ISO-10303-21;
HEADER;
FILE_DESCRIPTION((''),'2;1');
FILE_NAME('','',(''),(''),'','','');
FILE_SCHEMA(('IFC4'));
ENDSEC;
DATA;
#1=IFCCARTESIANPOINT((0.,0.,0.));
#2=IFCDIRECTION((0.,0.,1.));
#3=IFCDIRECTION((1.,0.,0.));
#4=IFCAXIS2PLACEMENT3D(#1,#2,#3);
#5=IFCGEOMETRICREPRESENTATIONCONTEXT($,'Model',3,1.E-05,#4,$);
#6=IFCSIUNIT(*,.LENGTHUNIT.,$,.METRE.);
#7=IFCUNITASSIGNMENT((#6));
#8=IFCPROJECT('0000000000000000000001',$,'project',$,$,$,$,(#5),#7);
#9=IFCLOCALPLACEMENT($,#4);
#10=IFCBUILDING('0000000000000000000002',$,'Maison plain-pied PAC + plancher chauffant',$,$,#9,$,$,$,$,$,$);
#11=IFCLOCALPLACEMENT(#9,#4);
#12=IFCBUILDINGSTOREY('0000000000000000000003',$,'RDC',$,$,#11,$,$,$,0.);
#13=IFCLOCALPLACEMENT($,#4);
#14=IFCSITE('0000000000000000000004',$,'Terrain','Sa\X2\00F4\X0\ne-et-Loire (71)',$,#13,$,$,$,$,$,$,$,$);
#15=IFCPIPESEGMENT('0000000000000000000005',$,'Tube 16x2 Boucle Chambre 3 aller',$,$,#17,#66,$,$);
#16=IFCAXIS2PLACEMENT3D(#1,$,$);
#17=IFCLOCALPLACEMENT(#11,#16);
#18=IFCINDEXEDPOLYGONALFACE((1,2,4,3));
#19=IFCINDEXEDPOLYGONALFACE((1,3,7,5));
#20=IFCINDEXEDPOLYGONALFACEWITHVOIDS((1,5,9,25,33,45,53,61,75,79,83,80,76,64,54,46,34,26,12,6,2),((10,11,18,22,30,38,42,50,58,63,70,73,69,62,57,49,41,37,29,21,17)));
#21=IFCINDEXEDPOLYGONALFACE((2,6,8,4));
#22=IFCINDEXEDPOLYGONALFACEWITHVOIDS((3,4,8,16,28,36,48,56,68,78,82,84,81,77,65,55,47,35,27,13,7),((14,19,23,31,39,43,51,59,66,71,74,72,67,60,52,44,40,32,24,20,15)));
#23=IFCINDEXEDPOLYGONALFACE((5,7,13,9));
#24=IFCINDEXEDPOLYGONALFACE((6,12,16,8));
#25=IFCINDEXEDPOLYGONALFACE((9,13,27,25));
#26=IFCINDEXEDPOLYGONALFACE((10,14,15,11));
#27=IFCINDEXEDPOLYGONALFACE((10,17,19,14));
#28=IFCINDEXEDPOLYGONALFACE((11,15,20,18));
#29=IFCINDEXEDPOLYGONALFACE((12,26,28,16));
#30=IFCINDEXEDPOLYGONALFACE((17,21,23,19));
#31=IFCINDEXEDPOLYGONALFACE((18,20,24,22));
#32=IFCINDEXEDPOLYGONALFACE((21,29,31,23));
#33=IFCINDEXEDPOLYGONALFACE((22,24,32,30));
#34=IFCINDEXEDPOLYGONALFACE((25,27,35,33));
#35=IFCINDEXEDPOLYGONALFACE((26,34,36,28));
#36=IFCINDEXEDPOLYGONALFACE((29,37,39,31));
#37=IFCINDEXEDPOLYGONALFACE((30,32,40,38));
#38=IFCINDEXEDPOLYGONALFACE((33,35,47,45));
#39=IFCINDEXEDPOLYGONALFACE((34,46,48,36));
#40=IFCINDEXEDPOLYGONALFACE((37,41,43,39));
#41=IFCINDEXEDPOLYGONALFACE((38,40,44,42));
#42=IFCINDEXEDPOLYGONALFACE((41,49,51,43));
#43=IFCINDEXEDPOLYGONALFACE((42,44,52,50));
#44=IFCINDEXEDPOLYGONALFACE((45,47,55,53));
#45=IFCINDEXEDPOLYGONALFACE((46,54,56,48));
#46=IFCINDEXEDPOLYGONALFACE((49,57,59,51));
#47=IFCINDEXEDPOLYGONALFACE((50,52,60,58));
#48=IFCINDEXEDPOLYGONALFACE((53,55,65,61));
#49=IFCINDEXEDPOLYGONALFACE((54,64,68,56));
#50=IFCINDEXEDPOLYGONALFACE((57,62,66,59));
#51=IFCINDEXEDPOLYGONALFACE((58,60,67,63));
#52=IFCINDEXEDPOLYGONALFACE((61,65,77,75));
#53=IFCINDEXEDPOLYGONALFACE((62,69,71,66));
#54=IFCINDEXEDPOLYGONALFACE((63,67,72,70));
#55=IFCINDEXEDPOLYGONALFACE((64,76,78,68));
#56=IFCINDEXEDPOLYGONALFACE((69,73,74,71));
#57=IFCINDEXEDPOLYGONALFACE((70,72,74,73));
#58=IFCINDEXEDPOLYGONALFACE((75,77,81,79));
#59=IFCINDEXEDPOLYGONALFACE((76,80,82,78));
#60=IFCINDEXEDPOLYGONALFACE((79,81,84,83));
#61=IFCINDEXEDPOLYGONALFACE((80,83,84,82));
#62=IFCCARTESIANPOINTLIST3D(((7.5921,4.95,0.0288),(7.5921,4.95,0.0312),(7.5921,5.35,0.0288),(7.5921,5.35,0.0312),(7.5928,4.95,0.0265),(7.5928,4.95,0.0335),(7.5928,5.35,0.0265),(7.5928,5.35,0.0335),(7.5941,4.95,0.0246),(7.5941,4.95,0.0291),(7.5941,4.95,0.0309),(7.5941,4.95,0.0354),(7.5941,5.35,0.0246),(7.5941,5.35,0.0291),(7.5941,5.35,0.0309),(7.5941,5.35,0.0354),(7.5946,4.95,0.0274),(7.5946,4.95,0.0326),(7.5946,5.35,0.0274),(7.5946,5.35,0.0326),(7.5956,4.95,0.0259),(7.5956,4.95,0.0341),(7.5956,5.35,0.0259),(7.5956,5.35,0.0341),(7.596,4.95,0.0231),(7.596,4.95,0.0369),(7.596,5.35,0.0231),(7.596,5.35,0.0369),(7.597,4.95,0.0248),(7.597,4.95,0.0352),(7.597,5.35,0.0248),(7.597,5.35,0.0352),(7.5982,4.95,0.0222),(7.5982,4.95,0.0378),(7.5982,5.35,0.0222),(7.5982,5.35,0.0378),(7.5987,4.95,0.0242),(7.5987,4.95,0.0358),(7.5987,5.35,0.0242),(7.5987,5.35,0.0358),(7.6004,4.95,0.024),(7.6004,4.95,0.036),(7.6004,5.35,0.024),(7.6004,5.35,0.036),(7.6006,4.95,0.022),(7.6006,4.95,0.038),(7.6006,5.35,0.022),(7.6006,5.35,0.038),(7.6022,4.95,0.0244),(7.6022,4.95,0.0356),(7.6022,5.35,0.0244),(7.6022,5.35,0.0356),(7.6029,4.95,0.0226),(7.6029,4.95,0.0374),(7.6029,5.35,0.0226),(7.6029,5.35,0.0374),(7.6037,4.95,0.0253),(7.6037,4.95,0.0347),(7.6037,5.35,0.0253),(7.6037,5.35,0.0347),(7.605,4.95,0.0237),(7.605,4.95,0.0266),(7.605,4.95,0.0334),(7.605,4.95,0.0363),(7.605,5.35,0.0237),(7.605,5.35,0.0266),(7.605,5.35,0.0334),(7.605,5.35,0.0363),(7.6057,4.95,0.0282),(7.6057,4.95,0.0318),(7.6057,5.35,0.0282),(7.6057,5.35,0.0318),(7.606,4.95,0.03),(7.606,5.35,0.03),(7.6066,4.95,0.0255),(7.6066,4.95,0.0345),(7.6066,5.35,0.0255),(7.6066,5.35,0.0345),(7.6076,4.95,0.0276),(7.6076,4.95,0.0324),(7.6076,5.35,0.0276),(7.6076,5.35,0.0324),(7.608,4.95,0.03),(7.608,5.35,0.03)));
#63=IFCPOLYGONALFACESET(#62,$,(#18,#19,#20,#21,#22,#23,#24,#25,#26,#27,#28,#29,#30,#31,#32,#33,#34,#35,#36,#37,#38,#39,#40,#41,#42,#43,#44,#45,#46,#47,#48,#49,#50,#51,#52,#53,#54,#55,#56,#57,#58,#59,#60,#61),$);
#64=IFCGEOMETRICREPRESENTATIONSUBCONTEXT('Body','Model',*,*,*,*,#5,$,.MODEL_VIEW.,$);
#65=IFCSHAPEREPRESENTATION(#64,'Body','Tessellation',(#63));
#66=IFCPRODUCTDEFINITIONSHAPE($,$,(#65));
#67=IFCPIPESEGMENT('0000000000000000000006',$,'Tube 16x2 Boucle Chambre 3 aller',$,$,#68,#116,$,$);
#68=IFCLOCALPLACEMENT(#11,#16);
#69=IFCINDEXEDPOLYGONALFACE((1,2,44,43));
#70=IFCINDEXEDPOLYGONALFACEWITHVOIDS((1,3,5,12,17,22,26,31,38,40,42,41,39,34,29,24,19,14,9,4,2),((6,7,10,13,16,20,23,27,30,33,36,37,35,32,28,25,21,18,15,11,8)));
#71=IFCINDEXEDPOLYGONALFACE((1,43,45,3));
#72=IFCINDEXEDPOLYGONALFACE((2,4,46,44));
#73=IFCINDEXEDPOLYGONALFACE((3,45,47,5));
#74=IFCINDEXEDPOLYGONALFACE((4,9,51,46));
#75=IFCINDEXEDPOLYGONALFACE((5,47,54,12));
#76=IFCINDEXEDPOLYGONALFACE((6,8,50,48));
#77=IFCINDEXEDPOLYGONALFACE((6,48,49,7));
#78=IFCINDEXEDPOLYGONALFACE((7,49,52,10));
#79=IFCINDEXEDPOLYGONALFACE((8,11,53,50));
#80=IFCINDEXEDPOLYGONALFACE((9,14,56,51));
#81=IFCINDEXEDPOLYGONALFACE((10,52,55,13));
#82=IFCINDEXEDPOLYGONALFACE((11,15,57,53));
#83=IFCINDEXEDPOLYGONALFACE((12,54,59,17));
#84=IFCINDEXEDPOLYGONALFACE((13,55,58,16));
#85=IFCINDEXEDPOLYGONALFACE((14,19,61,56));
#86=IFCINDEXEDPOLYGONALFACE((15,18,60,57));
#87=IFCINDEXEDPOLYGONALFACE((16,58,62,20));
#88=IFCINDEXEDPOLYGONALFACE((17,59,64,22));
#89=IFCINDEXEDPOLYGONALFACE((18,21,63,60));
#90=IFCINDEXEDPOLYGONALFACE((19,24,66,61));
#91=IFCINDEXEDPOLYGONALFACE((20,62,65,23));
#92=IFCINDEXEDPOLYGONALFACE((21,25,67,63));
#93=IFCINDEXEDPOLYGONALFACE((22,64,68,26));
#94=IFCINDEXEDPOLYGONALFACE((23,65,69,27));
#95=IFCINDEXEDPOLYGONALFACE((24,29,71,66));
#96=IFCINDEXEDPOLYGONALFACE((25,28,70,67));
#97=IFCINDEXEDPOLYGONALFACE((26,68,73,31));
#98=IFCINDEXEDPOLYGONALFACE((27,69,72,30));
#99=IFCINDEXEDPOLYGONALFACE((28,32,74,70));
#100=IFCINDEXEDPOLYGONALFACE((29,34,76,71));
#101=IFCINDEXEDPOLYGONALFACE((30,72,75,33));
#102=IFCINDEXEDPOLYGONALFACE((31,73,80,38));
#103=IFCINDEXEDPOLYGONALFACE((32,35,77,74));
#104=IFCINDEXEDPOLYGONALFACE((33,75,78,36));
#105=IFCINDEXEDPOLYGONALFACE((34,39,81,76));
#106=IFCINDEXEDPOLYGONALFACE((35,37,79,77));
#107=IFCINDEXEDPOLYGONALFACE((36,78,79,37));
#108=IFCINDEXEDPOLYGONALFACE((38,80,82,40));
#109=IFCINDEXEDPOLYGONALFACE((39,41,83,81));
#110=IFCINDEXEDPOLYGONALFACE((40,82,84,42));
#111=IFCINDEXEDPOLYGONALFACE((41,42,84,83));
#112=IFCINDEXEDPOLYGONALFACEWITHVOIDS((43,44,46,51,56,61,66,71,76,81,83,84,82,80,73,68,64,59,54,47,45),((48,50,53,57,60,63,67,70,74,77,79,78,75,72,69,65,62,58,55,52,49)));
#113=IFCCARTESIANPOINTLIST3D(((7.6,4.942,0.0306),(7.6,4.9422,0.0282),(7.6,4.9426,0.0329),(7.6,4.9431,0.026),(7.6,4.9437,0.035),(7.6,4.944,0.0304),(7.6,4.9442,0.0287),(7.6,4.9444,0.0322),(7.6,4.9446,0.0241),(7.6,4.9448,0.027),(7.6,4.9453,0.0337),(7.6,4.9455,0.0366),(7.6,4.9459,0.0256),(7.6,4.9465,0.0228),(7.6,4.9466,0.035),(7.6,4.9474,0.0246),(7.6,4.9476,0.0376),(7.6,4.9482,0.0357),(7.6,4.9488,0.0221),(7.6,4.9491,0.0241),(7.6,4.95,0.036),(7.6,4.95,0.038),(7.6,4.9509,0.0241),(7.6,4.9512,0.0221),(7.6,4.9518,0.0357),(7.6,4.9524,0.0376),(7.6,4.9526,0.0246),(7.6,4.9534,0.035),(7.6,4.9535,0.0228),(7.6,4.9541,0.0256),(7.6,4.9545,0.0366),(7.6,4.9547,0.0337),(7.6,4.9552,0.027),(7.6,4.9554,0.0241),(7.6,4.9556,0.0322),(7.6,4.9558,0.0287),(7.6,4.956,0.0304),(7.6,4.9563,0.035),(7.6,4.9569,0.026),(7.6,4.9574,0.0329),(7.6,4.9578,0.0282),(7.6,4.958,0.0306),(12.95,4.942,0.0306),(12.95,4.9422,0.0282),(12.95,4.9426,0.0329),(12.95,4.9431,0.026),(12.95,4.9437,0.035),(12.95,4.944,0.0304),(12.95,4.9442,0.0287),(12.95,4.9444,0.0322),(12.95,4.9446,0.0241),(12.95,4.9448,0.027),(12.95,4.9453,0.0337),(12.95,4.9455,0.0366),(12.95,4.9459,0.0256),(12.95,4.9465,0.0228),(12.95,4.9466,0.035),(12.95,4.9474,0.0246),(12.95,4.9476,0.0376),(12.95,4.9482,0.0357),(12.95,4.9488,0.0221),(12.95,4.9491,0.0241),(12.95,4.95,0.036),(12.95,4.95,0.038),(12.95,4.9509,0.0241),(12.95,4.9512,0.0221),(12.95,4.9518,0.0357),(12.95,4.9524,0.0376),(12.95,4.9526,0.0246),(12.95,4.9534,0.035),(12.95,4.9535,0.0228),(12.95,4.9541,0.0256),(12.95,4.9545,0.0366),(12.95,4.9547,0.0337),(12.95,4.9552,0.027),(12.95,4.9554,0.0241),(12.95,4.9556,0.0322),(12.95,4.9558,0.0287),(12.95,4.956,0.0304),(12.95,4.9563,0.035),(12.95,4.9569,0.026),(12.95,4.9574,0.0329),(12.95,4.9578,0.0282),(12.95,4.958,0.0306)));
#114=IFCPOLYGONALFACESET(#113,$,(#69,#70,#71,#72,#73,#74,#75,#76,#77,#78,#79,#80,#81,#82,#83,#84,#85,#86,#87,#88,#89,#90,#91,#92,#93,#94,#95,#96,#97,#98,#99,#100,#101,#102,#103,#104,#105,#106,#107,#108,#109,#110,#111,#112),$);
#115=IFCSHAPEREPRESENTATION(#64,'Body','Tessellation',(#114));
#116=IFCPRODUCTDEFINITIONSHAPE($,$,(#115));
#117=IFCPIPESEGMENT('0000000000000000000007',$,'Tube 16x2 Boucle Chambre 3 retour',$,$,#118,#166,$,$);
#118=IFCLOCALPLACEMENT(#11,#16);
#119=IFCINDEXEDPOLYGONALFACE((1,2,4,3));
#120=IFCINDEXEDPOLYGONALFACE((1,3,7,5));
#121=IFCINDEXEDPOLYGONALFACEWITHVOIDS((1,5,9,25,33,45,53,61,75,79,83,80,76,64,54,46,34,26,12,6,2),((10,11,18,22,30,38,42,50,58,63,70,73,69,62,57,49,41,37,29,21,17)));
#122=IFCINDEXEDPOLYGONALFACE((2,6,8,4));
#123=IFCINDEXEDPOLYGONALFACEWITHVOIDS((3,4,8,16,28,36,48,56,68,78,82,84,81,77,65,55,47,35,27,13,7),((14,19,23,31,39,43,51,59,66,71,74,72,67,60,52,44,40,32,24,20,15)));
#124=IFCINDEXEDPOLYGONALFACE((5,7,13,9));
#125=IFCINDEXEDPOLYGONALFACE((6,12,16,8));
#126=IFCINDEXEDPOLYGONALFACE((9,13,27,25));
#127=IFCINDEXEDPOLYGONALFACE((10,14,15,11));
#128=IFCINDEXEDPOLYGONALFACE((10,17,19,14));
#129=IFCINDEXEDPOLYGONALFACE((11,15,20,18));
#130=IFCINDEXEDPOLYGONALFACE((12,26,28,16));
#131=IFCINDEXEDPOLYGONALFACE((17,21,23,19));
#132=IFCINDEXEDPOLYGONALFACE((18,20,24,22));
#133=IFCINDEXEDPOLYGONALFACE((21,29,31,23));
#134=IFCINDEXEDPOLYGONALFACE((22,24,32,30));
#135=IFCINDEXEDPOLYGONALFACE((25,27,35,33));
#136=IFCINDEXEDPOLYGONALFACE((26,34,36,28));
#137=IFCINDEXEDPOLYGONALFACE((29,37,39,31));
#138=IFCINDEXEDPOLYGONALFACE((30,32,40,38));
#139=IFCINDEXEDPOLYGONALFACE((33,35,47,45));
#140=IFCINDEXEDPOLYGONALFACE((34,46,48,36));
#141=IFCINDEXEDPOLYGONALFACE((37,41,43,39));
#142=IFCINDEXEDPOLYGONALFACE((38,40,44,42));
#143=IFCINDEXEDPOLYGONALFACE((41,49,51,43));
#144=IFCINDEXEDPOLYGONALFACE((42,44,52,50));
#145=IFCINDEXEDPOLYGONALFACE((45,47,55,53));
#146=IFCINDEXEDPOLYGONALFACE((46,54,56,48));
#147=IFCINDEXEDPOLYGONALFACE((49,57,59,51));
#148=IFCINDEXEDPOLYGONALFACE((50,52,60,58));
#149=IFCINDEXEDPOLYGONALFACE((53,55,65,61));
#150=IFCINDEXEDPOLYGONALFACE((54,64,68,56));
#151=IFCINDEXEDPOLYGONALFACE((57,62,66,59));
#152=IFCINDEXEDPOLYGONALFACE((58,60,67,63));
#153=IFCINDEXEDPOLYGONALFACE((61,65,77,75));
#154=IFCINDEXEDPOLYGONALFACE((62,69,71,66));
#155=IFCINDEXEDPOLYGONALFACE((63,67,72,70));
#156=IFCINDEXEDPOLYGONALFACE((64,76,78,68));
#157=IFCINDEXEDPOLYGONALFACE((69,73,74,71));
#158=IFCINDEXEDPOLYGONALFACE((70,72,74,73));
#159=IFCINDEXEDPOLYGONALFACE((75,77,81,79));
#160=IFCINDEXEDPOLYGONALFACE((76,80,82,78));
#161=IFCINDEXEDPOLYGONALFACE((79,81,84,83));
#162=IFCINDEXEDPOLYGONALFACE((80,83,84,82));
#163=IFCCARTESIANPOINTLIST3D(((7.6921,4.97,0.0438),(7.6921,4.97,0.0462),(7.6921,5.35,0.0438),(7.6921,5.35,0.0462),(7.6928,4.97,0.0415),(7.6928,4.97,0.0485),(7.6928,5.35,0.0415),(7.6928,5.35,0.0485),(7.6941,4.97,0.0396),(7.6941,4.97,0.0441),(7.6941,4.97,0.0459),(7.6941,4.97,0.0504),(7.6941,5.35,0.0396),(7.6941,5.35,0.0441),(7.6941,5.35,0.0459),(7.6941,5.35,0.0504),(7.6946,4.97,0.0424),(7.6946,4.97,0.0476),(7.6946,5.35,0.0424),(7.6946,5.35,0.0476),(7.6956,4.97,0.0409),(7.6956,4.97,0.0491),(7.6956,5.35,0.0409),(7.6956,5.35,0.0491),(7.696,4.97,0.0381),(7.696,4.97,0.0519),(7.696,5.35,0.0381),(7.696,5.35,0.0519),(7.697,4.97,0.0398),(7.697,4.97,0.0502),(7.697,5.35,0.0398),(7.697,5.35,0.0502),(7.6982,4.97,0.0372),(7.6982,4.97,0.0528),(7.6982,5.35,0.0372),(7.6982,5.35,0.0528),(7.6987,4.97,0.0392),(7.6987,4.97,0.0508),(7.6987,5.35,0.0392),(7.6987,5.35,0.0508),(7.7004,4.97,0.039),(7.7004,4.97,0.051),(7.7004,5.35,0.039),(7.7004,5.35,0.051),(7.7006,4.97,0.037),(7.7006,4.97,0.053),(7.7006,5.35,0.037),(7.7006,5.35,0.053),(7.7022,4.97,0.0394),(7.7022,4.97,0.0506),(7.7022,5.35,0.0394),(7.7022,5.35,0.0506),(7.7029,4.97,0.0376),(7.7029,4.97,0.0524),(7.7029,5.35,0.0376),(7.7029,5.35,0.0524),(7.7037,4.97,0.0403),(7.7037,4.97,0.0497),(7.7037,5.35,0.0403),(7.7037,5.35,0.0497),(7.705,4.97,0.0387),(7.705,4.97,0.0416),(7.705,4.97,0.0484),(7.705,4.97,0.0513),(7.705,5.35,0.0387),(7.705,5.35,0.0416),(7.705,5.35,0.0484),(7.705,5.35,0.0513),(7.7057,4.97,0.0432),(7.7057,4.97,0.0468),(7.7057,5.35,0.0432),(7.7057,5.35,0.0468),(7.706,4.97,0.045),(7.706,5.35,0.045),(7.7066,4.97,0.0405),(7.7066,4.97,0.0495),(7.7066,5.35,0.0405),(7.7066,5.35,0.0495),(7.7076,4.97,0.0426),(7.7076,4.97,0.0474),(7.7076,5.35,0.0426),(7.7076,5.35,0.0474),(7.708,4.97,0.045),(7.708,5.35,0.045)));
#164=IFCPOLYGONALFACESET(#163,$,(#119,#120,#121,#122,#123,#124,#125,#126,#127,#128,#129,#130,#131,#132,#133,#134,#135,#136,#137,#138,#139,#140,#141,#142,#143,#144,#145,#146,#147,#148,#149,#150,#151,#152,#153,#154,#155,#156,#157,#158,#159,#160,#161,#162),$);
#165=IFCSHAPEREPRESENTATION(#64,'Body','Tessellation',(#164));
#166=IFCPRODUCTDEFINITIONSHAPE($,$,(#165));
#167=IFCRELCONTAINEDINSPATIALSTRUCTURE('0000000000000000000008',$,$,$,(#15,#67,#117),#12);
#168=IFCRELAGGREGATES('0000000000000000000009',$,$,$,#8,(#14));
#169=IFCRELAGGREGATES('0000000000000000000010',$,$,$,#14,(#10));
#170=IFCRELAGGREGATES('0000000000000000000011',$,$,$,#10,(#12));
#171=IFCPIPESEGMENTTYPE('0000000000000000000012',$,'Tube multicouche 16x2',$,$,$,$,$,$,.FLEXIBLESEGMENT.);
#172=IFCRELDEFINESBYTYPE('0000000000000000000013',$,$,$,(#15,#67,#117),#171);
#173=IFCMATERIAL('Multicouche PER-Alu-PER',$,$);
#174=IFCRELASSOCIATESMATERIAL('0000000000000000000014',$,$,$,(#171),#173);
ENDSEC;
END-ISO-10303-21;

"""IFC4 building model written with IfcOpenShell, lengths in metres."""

from ifc_helpers import new_model, si_unit, frame, origin_with_axes, place, context, subcontext, project, spatial, hollow_circle, extrude, material, type_object, element, save


model = new_model("IFC4")

# Units and contexts
model_context = context("Model", 3, precision=1e-05, world=origin_with_axes())
body_context = subcontext(model_context, "Body", "Model", "MODEL_VIEW")
ifc_project = project(units=[si_unit("LENGTHUNIT", "METRE")], contexts=[model_context])

# Site, building, storey
site_placement = place(None, origin_with_axes())
site = spatial("IfcSite", under=ifc_project, at=site_placement, Name="Terrain", Description="Saône-et-Loire (71)")
building_placement = place(None, origin_with_axes())
building = spatial("IfcBuilding", under=site, at=building_placement, Name="Maison plain-pied PAC + plancher chauffant")
storey_placement = place(building_placement, origin_with_axes())
storey = spatial("IfcBuildingStorey", under=building, at=storey_placement, Name="RDC", Elevation=0.0)

# Pipe segments
ifc_material_1 = material(Name="Multicouche PER-Alu-PER")
pipe_segment_type_1 = type_object("IfcPipeSegmentType", Name="Tube multicouche 16x2", PredefinedType="FLEXIBLESEGMENT", material=ifc_material_1)
pipe_segment_1_placement = place(storey_placement, frame((7.6, 5.35, 0.03), z_axis=(0.0, -1.0, 0.0), x_axis=(1.0, 0.0, 0.0)))
element("IfcPipeSegment", 1, at=pipe_segment_1_placement, inside=storey, type_object=pipe_segment_type_1, Name="Tube 16x2 Boucle Chambre 3 aller", context=body_context, shape_type="SweptSolid", body=[
    extrude(hollow_circle(Radius=0.008, WallThickness=0.002), origin_with_axes(), (0.0, 0.0, 1.0), 0.4),
])
pipe_segment_2_placement = place(storey_placement, frame((7.6, 4.95, 0.03), z_axis=(1.0, 0.0, 0.0), x_axis=(0.0, 0.0, 1.0)))
element("IfcPipeSegment", 2, at=pipe_segment_2_placement, inside=storey, type_object=pipe_segment_type_1, Name="Tube 16x2 Boucle Chambre 3 aller", context=body_context, shape_type="SweptSolid", body=[
    extrude(hollow_circle(Radius=0.008, WallThickness=0.002), origin_with_axes(), (0.0, 0.0, 1.0), 5.35),
])
pipe_segment_3_placement = place(storey_placement, frame((7.7, 4.97, 0.045), z_axis=(0.0, 1.0, 0.0), x_axis=(1.0, 0.0, 0.0)))
element("IfcPipeSegment", 3, at=pipe_segment_3_placement, inside=storey, type_object=pipe_segment_type_1, Name="Tube 16x2 Boucle Chambre 3 retour", context=body_context, shape_type="SweptSolid", body=[
    extrude(hollow_circle(Radius=0.008, WallThickness=0.002), origin_with_axes(), (0.0, 0.0, 1.0), 0.38),
])

save(model, "model.ifc")
